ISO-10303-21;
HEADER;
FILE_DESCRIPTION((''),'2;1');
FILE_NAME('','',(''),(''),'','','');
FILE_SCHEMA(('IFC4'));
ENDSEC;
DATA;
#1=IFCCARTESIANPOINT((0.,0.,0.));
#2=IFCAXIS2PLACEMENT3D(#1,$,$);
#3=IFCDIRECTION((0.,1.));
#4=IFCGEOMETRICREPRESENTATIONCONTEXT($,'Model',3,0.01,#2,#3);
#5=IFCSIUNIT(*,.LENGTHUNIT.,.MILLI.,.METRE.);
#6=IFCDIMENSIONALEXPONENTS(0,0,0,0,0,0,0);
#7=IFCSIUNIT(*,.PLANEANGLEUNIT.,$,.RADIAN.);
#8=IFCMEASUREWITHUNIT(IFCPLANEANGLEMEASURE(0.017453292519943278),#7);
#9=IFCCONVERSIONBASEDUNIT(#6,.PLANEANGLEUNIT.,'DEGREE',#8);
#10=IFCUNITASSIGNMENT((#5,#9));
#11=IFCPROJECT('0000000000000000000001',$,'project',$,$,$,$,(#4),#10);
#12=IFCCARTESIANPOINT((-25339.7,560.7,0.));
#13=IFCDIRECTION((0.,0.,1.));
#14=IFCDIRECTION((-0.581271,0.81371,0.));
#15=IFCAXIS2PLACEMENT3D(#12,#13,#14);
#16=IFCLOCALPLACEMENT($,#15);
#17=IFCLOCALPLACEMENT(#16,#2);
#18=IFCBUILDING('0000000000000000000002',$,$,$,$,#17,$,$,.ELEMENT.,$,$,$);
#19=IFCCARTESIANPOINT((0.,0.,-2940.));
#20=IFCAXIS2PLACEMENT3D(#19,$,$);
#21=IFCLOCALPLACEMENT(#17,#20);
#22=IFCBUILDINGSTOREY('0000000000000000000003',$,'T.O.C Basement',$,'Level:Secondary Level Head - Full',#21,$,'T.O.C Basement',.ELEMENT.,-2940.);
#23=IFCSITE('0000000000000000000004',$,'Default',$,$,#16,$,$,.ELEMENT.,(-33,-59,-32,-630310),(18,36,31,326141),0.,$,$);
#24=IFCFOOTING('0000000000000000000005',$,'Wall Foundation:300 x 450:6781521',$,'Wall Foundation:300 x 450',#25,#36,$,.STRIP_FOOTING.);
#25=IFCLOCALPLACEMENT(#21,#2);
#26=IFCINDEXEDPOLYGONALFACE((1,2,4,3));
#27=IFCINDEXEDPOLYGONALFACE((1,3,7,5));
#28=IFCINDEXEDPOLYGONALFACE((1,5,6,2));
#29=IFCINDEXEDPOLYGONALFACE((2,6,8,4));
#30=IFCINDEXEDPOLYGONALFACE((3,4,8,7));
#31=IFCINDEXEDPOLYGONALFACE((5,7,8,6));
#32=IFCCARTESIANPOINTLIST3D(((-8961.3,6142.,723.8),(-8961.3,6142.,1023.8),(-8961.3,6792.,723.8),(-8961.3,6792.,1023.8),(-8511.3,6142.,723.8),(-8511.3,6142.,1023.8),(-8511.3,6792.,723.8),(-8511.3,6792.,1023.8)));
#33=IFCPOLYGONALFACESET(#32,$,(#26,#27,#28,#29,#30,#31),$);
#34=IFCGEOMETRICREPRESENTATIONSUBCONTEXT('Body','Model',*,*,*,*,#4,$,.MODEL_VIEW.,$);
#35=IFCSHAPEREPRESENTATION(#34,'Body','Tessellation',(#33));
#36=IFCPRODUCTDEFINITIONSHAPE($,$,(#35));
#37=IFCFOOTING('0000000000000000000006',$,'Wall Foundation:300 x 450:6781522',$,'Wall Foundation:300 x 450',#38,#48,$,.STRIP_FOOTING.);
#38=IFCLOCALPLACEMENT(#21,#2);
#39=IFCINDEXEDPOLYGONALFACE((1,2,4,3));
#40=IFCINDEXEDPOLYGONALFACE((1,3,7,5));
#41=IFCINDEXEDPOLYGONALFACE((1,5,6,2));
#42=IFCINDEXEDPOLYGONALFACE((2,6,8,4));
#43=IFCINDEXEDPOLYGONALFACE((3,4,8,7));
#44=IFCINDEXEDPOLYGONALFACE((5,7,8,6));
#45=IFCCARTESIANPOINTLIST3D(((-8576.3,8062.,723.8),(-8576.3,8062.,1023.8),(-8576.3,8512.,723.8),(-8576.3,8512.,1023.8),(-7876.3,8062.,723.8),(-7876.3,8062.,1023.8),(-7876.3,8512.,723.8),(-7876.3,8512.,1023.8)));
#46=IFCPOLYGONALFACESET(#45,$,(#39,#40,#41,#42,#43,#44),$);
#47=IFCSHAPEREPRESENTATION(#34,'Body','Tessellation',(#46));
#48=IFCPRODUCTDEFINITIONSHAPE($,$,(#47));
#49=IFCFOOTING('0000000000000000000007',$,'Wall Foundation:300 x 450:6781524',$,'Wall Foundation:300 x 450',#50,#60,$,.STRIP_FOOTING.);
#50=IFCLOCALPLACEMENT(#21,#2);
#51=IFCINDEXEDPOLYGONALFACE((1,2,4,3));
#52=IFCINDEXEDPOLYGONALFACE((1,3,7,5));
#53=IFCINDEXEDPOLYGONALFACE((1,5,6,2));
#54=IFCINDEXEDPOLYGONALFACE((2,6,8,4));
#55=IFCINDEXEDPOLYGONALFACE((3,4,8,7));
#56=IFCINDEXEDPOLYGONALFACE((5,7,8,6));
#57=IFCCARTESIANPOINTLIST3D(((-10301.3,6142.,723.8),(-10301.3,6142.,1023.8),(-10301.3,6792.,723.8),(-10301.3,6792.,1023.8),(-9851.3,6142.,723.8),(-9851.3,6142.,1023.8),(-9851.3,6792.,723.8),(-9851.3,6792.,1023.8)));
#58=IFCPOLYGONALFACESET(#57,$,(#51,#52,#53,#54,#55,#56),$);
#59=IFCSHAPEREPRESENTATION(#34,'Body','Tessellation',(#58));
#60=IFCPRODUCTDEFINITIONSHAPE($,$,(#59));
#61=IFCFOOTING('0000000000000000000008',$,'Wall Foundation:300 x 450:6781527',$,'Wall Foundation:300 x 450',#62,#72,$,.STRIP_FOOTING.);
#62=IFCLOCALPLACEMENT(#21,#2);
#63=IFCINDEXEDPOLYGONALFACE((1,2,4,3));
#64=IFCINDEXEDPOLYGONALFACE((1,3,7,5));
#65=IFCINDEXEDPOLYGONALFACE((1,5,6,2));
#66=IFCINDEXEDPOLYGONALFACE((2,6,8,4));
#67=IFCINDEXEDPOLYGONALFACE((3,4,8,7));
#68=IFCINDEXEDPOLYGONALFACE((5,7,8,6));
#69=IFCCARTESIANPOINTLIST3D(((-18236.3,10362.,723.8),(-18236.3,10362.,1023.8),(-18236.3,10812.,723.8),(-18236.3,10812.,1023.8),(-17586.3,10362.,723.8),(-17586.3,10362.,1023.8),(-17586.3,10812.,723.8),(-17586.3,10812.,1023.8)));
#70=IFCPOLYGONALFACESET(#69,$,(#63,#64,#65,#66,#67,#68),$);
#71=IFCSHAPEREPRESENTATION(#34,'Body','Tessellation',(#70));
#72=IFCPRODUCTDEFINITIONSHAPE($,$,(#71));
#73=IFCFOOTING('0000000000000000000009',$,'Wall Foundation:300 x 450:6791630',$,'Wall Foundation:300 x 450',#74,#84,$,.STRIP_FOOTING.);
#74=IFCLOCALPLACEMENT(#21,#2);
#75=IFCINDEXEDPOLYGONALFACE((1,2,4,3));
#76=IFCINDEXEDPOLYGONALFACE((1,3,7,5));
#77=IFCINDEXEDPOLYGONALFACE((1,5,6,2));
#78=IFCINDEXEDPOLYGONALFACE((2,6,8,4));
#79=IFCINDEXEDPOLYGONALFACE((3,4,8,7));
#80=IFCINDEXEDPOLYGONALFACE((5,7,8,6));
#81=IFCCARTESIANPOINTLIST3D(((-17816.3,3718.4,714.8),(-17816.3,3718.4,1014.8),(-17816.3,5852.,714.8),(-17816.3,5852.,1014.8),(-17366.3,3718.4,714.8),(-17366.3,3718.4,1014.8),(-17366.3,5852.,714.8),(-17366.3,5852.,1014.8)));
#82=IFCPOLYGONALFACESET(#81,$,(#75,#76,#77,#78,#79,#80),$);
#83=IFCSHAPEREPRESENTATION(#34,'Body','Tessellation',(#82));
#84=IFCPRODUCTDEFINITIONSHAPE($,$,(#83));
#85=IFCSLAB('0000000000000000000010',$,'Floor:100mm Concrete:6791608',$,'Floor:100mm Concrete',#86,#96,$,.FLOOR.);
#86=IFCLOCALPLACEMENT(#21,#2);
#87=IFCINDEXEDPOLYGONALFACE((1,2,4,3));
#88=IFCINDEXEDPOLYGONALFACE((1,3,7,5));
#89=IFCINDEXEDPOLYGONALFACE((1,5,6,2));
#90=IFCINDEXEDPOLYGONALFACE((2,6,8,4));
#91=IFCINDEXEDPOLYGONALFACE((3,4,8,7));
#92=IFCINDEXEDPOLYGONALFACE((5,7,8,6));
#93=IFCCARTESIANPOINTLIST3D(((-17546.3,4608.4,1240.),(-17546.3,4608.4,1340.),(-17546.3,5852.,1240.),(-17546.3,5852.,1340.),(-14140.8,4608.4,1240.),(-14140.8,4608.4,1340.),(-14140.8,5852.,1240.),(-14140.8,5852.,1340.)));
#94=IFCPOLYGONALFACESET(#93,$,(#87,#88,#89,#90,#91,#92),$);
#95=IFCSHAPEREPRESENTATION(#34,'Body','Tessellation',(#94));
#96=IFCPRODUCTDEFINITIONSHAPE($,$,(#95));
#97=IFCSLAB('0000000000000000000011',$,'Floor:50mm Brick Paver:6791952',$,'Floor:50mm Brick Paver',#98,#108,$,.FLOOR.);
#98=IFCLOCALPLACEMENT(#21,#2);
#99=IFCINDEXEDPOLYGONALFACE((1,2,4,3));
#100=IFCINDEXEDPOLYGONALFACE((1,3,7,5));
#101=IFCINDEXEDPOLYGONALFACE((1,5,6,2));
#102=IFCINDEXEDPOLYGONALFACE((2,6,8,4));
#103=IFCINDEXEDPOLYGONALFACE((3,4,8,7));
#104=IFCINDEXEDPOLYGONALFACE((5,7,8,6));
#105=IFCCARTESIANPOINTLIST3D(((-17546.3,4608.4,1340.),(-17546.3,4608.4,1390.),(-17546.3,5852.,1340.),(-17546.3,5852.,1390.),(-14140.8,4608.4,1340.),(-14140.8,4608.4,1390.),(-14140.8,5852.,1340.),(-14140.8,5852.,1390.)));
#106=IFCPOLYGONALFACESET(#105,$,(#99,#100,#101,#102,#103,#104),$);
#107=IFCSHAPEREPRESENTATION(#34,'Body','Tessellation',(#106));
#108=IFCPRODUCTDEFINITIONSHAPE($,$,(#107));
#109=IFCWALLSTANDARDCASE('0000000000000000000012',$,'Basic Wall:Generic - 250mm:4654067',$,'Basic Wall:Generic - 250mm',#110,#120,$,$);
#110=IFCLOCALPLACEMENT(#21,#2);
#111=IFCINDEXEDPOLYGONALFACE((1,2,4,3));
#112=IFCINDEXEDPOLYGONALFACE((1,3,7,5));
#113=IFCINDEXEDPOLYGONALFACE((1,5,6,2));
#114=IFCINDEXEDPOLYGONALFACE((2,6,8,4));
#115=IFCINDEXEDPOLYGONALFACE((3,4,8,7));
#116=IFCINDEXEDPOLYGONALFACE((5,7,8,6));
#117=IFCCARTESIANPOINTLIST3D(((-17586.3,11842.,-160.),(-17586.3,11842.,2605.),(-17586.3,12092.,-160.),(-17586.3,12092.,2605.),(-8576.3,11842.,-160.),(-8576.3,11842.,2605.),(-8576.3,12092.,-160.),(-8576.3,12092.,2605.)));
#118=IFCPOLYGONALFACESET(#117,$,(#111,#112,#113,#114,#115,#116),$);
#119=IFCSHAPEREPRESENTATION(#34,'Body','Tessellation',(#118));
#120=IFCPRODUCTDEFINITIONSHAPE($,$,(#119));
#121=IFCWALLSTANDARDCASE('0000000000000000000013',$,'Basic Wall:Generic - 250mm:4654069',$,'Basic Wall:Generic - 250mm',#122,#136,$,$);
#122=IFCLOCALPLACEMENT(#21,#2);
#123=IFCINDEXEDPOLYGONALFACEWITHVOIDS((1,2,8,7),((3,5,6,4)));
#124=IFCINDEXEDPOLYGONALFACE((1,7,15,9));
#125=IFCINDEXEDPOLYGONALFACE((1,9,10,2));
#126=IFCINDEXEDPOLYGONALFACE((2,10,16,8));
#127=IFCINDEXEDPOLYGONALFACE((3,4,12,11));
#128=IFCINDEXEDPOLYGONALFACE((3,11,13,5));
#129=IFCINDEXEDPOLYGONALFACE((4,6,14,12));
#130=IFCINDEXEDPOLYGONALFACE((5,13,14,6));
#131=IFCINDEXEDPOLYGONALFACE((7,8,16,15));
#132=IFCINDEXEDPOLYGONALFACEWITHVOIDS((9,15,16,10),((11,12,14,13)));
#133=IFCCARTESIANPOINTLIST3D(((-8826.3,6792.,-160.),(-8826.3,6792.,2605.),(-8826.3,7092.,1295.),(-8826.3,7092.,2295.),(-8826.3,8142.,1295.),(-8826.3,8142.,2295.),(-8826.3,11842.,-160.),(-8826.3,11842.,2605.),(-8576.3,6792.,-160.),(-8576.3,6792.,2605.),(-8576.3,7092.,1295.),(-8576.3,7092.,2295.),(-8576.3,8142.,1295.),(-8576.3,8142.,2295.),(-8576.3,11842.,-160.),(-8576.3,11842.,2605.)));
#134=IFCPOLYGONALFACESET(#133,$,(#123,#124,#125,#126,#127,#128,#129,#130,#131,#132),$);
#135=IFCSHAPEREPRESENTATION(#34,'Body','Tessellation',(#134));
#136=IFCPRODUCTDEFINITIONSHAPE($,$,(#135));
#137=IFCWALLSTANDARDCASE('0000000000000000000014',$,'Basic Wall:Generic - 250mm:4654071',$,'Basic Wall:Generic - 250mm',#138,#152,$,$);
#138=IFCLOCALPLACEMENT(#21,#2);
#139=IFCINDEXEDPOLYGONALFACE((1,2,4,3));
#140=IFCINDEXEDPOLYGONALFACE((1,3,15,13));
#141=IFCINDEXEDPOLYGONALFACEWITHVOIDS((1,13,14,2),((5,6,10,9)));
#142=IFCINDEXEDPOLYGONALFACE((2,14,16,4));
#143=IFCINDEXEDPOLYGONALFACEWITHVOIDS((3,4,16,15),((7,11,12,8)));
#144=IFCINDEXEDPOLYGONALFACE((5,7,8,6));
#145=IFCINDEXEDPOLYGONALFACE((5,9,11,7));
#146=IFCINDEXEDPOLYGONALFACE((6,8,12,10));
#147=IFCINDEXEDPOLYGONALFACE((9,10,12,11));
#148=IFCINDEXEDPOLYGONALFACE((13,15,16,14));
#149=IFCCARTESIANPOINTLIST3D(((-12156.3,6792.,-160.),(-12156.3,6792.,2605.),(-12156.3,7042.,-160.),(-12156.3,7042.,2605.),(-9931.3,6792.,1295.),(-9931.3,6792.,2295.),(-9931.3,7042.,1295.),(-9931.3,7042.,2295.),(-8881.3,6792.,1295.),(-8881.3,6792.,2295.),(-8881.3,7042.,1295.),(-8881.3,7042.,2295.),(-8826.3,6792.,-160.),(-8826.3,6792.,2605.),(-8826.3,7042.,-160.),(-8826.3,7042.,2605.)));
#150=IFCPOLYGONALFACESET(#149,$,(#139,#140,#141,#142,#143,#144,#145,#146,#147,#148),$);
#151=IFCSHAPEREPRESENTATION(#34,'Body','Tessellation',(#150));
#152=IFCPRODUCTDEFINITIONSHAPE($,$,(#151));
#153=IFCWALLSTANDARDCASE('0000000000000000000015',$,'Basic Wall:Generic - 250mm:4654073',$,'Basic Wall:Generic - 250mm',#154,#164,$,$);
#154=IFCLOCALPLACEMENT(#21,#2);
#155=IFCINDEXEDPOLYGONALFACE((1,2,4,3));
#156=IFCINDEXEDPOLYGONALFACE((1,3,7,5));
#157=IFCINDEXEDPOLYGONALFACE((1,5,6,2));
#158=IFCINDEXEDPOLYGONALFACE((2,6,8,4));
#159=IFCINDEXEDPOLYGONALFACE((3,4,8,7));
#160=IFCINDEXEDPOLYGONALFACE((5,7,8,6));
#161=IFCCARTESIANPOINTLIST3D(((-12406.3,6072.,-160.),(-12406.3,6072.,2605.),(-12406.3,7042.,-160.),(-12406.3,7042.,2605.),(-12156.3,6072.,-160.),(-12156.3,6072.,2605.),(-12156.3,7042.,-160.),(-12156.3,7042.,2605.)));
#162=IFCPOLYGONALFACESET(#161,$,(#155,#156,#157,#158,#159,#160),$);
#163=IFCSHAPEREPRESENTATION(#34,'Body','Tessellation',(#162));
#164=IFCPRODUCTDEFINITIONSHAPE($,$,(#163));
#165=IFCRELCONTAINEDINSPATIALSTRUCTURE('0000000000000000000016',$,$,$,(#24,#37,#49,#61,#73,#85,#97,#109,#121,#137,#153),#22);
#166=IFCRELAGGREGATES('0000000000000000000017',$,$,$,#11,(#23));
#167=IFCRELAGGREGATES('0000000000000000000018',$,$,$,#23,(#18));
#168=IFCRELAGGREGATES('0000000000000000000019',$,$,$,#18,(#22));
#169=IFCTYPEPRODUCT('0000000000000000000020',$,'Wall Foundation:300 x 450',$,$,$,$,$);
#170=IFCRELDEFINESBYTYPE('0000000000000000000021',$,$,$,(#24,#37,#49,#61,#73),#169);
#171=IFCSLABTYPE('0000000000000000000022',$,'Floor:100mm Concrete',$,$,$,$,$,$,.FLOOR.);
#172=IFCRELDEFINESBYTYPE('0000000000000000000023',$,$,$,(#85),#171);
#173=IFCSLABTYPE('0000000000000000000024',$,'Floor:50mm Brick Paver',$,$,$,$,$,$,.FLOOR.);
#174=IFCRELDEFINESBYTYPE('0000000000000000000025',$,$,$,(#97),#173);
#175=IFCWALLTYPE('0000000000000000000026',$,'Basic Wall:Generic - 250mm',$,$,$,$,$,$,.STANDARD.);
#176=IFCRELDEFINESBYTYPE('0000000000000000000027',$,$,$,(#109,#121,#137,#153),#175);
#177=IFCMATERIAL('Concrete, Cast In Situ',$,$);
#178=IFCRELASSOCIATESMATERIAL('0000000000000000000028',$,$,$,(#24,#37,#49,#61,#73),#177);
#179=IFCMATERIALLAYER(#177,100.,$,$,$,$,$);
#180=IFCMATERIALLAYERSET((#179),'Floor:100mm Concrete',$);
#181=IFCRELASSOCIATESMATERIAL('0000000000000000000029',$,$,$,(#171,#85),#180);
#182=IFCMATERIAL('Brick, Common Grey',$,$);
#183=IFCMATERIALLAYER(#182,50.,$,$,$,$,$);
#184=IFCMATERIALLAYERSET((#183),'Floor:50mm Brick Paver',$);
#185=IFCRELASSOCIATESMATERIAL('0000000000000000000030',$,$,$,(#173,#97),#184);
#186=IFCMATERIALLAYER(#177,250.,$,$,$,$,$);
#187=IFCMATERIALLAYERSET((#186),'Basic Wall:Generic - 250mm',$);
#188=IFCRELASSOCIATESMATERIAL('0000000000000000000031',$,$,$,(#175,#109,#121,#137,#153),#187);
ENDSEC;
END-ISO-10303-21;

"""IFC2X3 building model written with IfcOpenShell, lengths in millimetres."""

from ifc_helpers import new_model, entity, si_unit, converted_unit, direction, frame, frame_2d, origin, origin_2d_with_axis, place, context, subcontext, project, spatial, polyline, rectangle, extrude, clip, bounded_halfspace, material, layer, layer_set, layer_usage, type_object, element, save


model = new_model("IFC2X3")

# Units and contexts
model_context = context("Model", 3, precision=0.01, world=origin(), true_north=direction((0.0, 1.0)))
body_context = subcontext(model_context, "Body", "Model", "MODEL_VIEW")
ifc_project = project(units=[si_unit("LENGTHUNIT", "METRE", prefix="MILLI"), converted_unit("PLANEANGLEUNIT", "DEGREE", entity("IfcPlaneAngleMeasure", 0.017453292519943278), si_unit("PLANEANGLEUNIT", "RADIAN"), dimensions=[0, 0, 0, 0, 0, 0, 0])], contexts=[model_context])

# Site, building, storey
site_placement = place(None, frame((-25339.7, 560.7, 0.0), z_axis=(0.0, 0.0, 1.0), x_axis=(-0.581271, 0.81371, 0.0)))
site = spatial("IfcSite", under=ifc_project, at=site_placement, Name="Default", CompositionType="ELEMENT", RefLatitude=(-33, -59, -32, -630310), RefLongitude=(18, 36, 31, 326141), RefElevation=0.0)
building_placement = place(site_placement, origin())
building = spatial("IfcBuilding", under=site, at=building_placement, CompositionType="ELEMENT")
storey_placement = place(building_placement, frame((0.0, 0.0, -2940.0)))
storey = spatial("IfcBuildingStorey", under=building, at=storey_placement, Name="T.O.C Basement", ObjectType="Level:Secondary Level Head - Full", LongName="T.O.C Basement", CompositionType="ELEMENT", Elevation=-2940.0)

# Footings
ifc_material_1 = material(Name="Concrete, Cast In Situ")
type_product = type_object("IfcTypeProduct", Name="Wall Foundation:300 x 450")
footing_1_placement = place(storey_placement, origin())
element("IfcFooting", 1, at=footing_1_placement, inside=storey, type_object=type_product, material=ifc_material_1, Name="Wall Foundation:300 x 450:6781521", ObjectType="Wall Foundation:300 x 450", PredefinedType="STRIP_FOOTING", context=body_context, shape_type="SweptSolid", body=[
    extrude(rectangle(XDim=650.0, YDim=450.0, at=frame_2d((0.0, 0.0), x_axis=(1.0, 0.0))), frame((-8736.3, 6467.0, 723.8), z_axis=(0.0, 0.0, 1.0), x_axis=(0.0, -1.0, 0.0)), (0.0, 0.0, 1.0), 300.0),
])
footing_2_placement = place(storey_placement, origin())
element("IfcFooting", 2, at=footing_2_placement, inside=storey, type_object=type_product, material=ifc_material_1, Name="Wall Foundation:300 x 450:6781522", ObjectType="Wall Foundation:300 x 450", PredefinedType="STRIP_FOOTING", context=body_context, shape_type="SweptSolid", body=[
    extrude(rectangle(XDim=700.0, YDim=450.0, at=frame_2d((0.0, 0.0), x_axis=(1.0, 0.0))), frame((-8226.3, 8287.0, 723.8)), (0.0, 0.0, 1.0), 300.0),
])
footing_3_placement = place(storey_placement, origin())
element("IfcFooting", 3, at=footing_3_placement, inside=storey, type_object=type_product, material=ifc_material_1, Name="Wall Foundation:300 x 450:6781524", ObjectType="Wall Foundation:300 x 450", PredefinedType="STRIP_FOOTING", context=body_context, shape_type="SweptSolid", body=[
    extrude(rectangle(XDim=650.0, YDim=450.0, at=origin_2d_with_axis()), frame((-10076.3, 6467.0, 723.8), z_axis=(0.0, 0.0, 1.0), x_axis=(0.0, -1.0, 0.0)), (0.0, 0.0, 1.0), 300.0),
])
footing_4_placement = place(storey_placement, origin())
element("IfcFooting", 4, at=footing_4_placement, inside=storey, type_object=type_product, material=ifc_material_1, Name="Wall Foundation:300 x 450:6781527", ObjectType="Wall Foundation:300 x 450", PredefinedType="STRIP_FOOTING", context=body_context, shape_type="SweptSolid", body=[
    extrude(rectangle(XDim=650.0, YDim=450.0, at=frame_2d((0.0, 0.0), x_axis=(1.0, 0.0))), frame((-17911.3, 10587.0, 723.8), z_axis=(0.0, 0.0, 1.0), x_axis=(-1.0, 0.0, 0.0)), (0.0, 0.0, 1.0), 300.0),
])
footing_5_placement = place(storey_placement, origin())
element("IfcFooting", 5, at=footing_5_placement, inside=storey, type_object=type_product, material=ifc_material_1, Name="Wall Foundation:300 x 450:6791630", ObjectType="Wall Foundation:300 x 450", PredefinedType="STRIP_FOOTING", context=body_context, shape_type="SweptSolid", body=[
    extrude(rectangle(XDim=2133.7, YDim=450.0, at=frame_2d((0.0, 0.0), x_axis=(1.0, 0.0))), frame((-17591.3, 4785.2, 714.8), z_axis=(0.0, 0.0, 1.0), x_axis=(0.0, -1.0, 0.0)), (0.0, 0.0, 1.0), 300.0),
])

# Slabs
ifc_layer_1 = layer(ifc_material_1, 100.0)
ifc_layer_set_1 = layer_set([ifc_layer_1], Name="Floor:100mm Concrete")
ifc_layer_usage_1 = layer_usage(ifc_layer_set_1, "AXIS3", "POSITIVE", 0.0)
slab_type_1 = type_object("IfcSlabType", Name="Floor:100mm Concrete", PredefinedType="FLOOR", material=ifc_layer_set_1)
slab_1_placement = place(storey_placement, origin())
element("IfcSlab", 6, at=slab_1_placement, inside=storey, type_object=slab_type_1, material=ifc_layer_usage_1, Name="Floor:100mm Concrete:6791608", ObjectType="Floor:100mm Concrete", PredefinedType="FLOOR", context=body_context, shape_type="SweptSolid", body=[
    extrude(rectangle(XDim=1243.7, YDim=3405.5, at=frame_2d((0.0, 0.0), x_axis=(1.0, 0.0))), frame((-15843.5, 5230.2, 1340.0), z_axis=(0.0, 0.0, -1.0), x_axis=(0.0, 1.0, 0.0)), (0.0, 0.0, 1.0), 100.0),
])
ifc_material_2 = material(Name="Brick, Common Grey")
ifc_layer_2 = layer(ifc_material_2, 50.0)
ifc_layer_set_2 = layer_set([ifc_layer_2], Name="Floor:50mm Brick Paver")
ifc_layer_usage_2 = layer_usage(ifc_layer_set_2, "AXIS3", "POSITIVE", 0.0)
slab_type_2 = type_object("IfcSlabType", Name="Floor:50mm Brick Paver", PredefinedType="FLOOR", material=ifc_layer_set_2)
slab_2_placement = place(storey_placement, origin())
element("IfcSlab", 7, at=slab_2_placement, inside=storey, type_object=slab_type_2, material=ifc_layer_usage_2, Name="Floor:50mm Brick Paver:6791952", ObjectType="Floor:50mm Brick Paver", PredefinedType="FLOOR", context=body_context, shape_type="SweptSolid", body=[
    extrude(rectangle(XDim=1243.7, YDim=3405.5, at=frame_2d((0.0, 0.0), x_axis=(1.0, 0.0))), frame((-15843.5, 5230.2, 1390.0), z_axis=(0.0, 0.0, -1.0), x_axis=(0.0, 1.0, 0.0)), (0.0, 0.0, 1.0), 50.0),
])

# Wall
ifc_layer_3 = layer(ifc_material_1, 250.0)
ifc_layer_set_3 = layer_set([ifc_layer_3], Name="Basic Wall:Generic - 250mm")
ifc_layer_usage_3 = layer_usage(ifc_layer_set_3, "AXIS2", "NEGATIVE", 125.0)
wall_type_1 = type_object("IfcWallType", Name="Basic Wall:Generic - 250mm", PredefinedType="STANDARD", material=ifc_layer_set_3)
wall_1_placement = place(storey_placement, frame((-17586.3, 11967.0, -160.0)))
element("IfcWallStandardCase", 8, at=wall_1_placement, inside=storey, type_object=wall_type_1, material=ifc_layer_usage_3, Name="Basic Wall:Generic - 250mm:4654067", ObjectType="Basic Wall:Generic - 250mm", context=body_context, shape_type="Clipping", body=[
    clip(extrude(rectangle(XDim=9010.0, YDim=250.0, at=frame_2d((4505.0, 0.0), x_axis=(-1.0, 0.0))), origin(), (0.0, 0.0, 1.0), 2765.0), bounded_halfspace(frame((0.0, 125.0, 2765.0), z_axis=(0.0, 0.0, -1.0), x_axis=(1.0, 0.0, 0.0)), True, frame((0.0, 125.0, 2765.0)), polyline([(0.0, 0.0), (0.0, -170.0), (0.0, -250.0), (250.0, -250.0), (8760.0, -250.0), (9010.0, -250.0), (9010.0, 0.0), (0.0, 0.0)]))),
])

# Walls, openings
ifc_layer_usage_4 = layer_usage(ifc_layer_set_3, "AXIS2", "NEGATIVE", 125.0)
wall_2_placement = place(storey_placement, frame((-8701.3, 11842.0, -160.0), z_axis=(0.0, 0.0, 1.0), x_axis=(0.0, -1.0, 0.0)))
wall_2 = element("IfcWallStandardCase", 9, at=wall_2_placement, inside=storey, type_object=wall_type_1, material=ifc_layer_usage_4, Name="Basic Wall:Generic - 250mm:4654069", ObjectType="Basic Wall:Generic - 250mm", context=body_context, shape_type="Clipping", body=[
    clip(extrude(rectangle(XDim=5050.0, YDim=250.0, at=frame_2d((2525.0, 0.0), x_axis=(-1.0, 0.0))), origin(), (0.0, 0.0, 1.0), 2765.0), bounded_halfspace(frame((0.0, -125.0, 2765.0), z_axis=(0.0, 0.0, -1.0), x_axis=(0.0, 1.0, 0.0)), True, frame((0.0, -125.0, 2765.0)), polyline([(0.0, 0.0), (10.0, 0.0), (2155.0, 0.0), (4800.0, 0.0), (5050.0, 0.0), (5050.0, 250.0), (0.0, 250.0), (0.0, 0.0)]))),
])
opening_1_placement = place(wall_2_placement, origin())
element("IfcOpeningElement", 10, at=opening_1_placement, cuts=wall_2, ObjectType="Opening", context=body_context, shape_type="SweptSolid", body=[
    extrude(rectangle(XDim=1000.0, YDim=1050.0, at=origin_2d_with_axis()), frame((4225.0, -125.0, 1955.0), z_axis=(0.0, 1.0, 0.0), x_axis=(0.0, 0.0, -1.0)), (0.0, 0.0, 1.0), 250.0),
])
ifc_layer_usage_5 = layer_usage(ifc_layer_set_3, "AXIS2", "NEGATIVE", 125.0)
wall_3_placement = place(storey_placement, frame((-8826.3, 6917.0, -160.0), z_axis=(0.0, 0.0, 1.0), x_axis=(-1.0, 0.0, 0.0)))
wall_3 = element("IfcWallStandardCase", 11, at=wall_3_placement, inside=storey, type_object=wall_type_1, material=ifc_layer_usage_5, Name="Basic Wall:Generic - 250mm:4654071", ObjectType="Basic Wall:Generic - 250mm", context=body_context, shape_type="Clipping", body=[
    clip(extrude(rectangle(XDim=3330.0, YDim=250.0, at=frame_2d((1665.0, 0.0), x_axis=(-1.0, 0.0))), origin(), (0.0, 0.0, 1.0), 2765.0), bounded_halfspace(frame((0.0, 125.0, 2765.0), z_axis=(0.0, 0.0, -1.0), x_axis=(-1.0, 0.0, 0.0)), True, frame((0.0, 125.0, 2765.0)), polyline([(0.0, 0.0), (0.0, -250.0), (3330.0, -250.0), (3330.0, 0.0), (0.0, 0.0)]))),
])
opening_2_placement = place(wall_3_placement, origin())
element("IfcOpeningElement", 12, at=opening_2_placement, cuts=wall_3, ObjectType="Opening", context=body_context, shape_type="SweptSolid", body=[
    extrude(rectangle(XDim=1000.0, YDim=1050.0, at=frame_2d((0.0, 0.0), x_axis=(1.0, 0.0))), frame((580.0, -125.0, 1955.0), z_axis=(0.0, 1.0, 0.0), x_axis=(0.0, 0.0, -1.0)), (0.0, 0.0, 1.0), 250.0),
])

# Wall
ifc_layer_usage_6 = layer_usage(ifc_layer_set_3, "AXIS2", "NEGATIVE", 125.0)
wall_4_placement = place(storey_placement, frame((-12281.3, 7042.0, -160.0), z_axis=(0.0, 0.0, 1.0), x_axis=(0.0, -1.0, 0.0)))
element("IfcWallStandardCase", 13, at=wall_4_placement, inside=storey, type_object=wall_type_1, material=ifc_layer_usage_6, Name="Basic Wall:Generic - 250mm:4654073", ObjectType="Basic Wall:Generic - 250mm", context=body_context, shape_type="Clipping", body=[
    clip(extrude(rectangle(XDim=970.0, YDim=250.0, at=frame_2d((485.0, 0.0), x_axis=(-1.0, 0.0))), origin(), (0.0, 0.0, 1.0), 2765.0), bounded_halfspace(frame((0.0, -125.0, 2765.0), z_axis=(0.0, 0.0, -1.0), x_axis=(0.0, 1.0, 0.0)), True, frame((0.0, -125.0, 2765.0)), polyline([(0.0, 0.0), (720.0, 0.0), (970.0, 0.0), (970.0, 250.0), (250.0, 250.0), (0.0, 250.0), (0.0, 0.0)]))),
])

save(model, "model.ifc")
